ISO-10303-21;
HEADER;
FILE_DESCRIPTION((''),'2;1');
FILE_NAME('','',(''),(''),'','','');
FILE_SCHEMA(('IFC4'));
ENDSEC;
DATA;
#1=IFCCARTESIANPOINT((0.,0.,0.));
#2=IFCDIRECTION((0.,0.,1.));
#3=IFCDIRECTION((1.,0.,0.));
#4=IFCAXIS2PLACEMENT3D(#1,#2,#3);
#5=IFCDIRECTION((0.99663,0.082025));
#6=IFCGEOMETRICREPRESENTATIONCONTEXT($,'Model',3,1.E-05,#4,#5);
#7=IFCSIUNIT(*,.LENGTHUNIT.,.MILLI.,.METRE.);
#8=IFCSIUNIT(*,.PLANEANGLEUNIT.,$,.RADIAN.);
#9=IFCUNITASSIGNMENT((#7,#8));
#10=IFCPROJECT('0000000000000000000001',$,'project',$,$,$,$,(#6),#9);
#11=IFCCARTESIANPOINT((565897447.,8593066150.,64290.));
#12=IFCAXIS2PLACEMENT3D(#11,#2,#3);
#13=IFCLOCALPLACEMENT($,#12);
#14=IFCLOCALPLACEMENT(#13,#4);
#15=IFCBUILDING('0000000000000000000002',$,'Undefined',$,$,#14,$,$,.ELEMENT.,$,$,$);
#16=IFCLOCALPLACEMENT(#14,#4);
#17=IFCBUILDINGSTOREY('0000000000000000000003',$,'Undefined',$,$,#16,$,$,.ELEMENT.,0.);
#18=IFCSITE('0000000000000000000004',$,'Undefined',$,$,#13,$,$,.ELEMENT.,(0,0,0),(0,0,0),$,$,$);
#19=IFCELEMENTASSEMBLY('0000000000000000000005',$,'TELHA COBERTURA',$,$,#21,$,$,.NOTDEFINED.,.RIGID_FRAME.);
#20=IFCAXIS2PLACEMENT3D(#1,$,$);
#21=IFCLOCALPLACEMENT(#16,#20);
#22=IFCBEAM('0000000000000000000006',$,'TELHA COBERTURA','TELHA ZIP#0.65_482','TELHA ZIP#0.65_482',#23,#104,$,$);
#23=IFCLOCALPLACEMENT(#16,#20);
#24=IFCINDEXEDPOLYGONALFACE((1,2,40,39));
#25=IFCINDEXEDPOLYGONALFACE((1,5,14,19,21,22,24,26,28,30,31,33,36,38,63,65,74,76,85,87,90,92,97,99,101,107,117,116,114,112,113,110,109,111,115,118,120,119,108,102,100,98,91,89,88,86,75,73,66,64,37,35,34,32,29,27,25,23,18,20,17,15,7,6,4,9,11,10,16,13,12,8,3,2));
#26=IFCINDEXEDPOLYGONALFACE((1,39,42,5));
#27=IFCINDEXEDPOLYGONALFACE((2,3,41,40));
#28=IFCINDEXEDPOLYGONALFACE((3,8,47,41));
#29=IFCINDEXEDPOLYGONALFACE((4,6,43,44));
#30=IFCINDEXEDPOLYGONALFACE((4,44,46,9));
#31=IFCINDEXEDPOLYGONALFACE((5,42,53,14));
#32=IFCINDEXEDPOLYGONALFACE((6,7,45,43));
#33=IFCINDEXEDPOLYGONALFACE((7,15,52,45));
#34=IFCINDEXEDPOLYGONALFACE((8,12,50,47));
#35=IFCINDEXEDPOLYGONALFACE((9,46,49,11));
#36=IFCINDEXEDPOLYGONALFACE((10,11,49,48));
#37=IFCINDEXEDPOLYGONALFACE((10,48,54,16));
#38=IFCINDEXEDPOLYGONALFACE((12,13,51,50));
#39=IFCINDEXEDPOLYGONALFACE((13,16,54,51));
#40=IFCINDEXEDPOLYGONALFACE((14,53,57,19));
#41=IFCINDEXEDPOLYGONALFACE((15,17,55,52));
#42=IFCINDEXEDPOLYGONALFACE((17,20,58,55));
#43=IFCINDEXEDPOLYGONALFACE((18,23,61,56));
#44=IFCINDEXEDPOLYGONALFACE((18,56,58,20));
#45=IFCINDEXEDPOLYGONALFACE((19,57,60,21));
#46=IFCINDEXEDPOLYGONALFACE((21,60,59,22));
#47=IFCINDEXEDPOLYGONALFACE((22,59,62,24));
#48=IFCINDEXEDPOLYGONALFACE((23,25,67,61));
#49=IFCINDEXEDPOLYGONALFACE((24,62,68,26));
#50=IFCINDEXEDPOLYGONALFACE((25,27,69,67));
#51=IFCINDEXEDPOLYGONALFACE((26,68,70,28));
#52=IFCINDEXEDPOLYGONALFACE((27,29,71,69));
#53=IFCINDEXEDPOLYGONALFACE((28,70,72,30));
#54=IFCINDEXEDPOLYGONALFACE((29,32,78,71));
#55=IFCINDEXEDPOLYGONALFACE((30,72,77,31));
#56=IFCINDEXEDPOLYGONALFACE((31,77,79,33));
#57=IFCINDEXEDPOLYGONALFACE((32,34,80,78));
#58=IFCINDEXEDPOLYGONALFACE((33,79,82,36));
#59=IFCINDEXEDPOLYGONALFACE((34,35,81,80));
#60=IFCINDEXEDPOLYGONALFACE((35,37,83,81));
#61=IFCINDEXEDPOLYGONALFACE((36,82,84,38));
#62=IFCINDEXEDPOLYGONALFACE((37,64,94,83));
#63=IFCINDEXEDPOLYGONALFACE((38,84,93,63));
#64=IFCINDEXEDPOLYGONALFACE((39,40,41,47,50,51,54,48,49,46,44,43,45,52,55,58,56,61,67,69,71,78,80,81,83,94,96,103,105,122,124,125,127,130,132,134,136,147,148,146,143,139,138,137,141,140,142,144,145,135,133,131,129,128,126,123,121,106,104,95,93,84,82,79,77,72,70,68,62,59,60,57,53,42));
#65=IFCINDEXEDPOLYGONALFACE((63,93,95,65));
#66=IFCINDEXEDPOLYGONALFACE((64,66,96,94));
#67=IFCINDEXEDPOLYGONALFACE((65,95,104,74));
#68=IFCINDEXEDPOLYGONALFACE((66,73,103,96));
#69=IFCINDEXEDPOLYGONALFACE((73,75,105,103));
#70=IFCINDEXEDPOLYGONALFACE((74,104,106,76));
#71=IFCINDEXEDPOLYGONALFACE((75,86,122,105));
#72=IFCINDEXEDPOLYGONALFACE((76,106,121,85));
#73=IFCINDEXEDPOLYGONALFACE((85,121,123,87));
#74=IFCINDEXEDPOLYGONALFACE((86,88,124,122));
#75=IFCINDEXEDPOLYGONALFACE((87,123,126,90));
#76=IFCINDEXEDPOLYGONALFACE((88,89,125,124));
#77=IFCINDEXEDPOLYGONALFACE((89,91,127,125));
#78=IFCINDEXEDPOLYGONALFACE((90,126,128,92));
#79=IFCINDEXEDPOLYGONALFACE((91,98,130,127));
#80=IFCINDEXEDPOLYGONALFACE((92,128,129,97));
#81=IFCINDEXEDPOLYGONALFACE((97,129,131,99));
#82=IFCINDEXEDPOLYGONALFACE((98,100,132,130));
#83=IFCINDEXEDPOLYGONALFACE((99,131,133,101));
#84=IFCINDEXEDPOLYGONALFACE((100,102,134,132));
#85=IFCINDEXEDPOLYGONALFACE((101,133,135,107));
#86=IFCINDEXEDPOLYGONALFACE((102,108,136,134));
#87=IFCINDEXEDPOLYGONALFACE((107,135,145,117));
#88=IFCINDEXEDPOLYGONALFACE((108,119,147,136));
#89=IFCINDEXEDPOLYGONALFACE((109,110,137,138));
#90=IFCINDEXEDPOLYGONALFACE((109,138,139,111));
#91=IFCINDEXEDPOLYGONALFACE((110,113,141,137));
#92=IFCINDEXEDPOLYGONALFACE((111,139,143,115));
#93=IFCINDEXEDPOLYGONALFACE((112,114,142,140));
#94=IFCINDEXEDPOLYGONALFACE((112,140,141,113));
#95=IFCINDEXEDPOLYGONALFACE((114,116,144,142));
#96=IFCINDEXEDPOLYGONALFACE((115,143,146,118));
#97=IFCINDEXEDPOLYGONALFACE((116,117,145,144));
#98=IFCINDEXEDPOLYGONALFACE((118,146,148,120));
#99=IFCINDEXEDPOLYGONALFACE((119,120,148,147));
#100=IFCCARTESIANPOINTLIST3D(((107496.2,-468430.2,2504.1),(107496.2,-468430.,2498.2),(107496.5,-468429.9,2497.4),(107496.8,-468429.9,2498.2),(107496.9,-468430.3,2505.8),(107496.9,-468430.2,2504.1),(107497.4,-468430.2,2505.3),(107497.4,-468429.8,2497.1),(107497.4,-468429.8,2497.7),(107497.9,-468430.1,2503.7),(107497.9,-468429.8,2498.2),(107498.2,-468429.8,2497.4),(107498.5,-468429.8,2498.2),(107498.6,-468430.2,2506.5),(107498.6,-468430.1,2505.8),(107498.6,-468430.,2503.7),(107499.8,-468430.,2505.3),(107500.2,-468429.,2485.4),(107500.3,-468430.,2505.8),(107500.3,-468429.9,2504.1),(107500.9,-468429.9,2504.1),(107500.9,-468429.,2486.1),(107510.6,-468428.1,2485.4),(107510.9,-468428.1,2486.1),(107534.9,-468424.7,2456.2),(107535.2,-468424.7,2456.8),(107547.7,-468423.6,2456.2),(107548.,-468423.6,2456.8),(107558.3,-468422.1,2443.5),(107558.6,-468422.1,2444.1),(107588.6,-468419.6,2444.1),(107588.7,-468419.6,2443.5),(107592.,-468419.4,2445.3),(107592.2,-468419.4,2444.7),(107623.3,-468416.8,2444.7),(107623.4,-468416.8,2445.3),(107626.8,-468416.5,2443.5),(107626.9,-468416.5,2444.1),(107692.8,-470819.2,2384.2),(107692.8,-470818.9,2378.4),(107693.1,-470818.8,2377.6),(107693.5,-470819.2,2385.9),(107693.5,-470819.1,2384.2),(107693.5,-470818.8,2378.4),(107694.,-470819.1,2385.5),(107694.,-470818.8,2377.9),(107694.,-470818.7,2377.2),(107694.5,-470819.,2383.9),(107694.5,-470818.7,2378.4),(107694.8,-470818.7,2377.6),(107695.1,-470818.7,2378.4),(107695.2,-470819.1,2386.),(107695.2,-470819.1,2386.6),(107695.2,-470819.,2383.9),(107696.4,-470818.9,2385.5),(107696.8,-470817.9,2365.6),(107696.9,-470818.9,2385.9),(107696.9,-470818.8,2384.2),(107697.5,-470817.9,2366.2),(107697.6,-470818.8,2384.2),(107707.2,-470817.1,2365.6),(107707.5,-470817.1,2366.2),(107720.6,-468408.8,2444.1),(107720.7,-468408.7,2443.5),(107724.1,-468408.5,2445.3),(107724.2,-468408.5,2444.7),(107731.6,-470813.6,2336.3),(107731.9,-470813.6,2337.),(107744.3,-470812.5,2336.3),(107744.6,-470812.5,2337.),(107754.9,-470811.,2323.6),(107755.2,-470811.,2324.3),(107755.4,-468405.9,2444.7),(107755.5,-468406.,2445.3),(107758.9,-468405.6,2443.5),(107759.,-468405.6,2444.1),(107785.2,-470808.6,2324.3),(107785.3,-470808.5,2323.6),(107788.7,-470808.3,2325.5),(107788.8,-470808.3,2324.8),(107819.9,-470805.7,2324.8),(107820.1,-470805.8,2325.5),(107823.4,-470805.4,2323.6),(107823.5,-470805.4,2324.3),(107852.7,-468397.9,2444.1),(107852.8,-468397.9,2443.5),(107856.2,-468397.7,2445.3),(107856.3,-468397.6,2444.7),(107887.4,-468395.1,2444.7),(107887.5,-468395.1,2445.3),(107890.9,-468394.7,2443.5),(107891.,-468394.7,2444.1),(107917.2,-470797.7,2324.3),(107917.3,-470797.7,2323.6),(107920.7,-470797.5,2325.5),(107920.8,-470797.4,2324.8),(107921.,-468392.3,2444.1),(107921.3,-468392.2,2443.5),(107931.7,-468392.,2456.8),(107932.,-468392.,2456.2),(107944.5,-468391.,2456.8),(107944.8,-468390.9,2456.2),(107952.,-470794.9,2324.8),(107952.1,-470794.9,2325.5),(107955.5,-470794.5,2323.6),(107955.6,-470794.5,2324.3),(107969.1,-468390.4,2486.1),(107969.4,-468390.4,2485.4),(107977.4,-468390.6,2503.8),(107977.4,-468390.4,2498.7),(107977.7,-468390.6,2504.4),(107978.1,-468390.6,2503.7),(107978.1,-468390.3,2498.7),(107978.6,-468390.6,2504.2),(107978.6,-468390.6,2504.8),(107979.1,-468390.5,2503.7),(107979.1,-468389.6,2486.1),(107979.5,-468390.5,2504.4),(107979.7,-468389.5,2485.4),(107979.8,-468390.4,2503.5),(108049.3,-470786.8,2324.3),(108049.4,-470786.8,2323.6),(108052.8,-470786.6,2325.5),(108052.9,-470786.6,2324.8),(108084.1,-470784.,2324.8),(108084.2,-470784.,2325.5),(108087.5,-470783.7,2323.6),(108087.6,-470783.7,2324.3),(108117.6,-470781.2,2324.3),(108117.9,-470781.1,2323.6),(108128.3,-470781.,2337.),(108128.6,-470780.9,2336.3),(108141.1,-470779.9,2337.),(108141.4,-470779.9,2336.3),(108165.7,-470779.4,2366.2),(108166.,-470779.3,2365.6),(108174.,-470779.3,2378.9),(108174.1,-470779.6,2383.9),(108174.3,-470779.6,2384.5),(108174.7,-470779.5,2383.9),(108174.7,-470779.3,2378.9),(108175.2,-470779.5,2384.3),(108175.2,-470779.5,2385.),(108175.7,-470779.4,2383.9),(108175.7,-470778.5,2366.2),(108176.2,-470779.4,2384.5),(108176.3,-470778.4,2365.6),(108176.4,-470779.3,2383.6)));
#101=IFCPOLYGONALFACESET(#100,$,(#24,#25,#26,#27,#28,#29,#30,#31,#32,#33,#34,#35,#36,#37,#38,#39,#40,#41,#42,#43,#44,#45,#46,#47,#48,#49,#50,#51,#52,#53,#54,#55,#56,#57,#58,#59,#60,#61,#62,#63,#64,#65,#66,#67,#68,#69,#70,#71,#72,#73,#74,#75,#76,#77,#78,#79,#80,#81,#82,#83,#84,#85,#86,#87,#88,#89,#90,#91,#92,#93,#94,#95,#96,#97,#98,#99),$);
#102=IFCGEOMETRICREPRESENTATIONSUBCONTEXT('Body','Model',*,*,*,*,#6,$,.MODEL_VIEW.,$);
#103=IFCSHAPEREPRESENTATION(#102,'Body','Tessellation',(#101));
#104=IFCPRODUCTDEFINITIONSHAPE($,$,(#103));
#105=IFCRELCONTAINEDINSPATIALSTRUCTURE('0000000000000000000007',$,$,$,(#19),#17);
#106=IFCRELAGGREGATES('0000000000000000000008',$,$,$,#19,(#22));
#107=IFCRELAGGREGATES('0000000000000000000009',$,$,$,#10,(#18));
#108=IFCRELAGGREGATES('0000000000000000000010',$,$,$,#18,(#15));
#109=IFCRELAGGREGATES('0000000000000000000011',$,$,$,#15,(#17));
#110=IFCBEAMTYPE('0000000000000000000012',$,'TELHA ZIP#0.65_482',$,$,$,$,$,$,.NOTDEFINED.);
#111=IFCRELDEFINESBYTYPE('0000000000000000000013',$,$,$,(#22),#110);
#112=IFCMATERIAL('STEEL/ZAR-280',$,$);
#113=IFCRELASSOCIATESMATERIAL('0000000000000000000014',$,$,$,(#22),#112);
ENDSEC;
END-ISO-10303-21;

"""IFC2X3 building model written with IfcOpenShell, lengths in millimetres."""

from ifc_helpers import new_model, si_unit, direction, frame, origin_with_axes, place, context, subcontext, project, spatial, polyline, outline, extrude, material, type_object, element, aggregate, save


model = new_model("IFC2X3")

# Units and contexts
model_context = context("Model", 3, precision=1e-05, world=origin_with_axes(), true_north=direction((0.99663, 0.082025)))
body_context = subcontext(model_context, "Body", "Model", "MODEL_VIEW")
ifc_project = project(units=[si_unit("LENGTHUNIT", "METRE", prefix="MILLI"), si_unit("PLANEANGLEUNIT", "RADIAN")], contexts=[model_context])

# Site, building, storey
site_placement = place(None, frame((565897447.0, 8593066150.0, 64290.0), z_axis=(0.0, 0.0, 1.0), x_axis=(1.0, 0.0, 0.0)))
site = spatial("IfcSite", under=ifc_project, at=site_placement, Name="Undefined", CompositionType="ELEMENT", RefLatitude=(0, 0, 0), RefLongitude=(0, 0, 0))
building_placement = place(site_placement, origin_with_axes())
building = spatial("IfcBuilding", under=site, at=building_placement, Name="Undefined", CompositionType="ELEMENT")
storey_placement = place(building_placement, origin_with_axes())
storey = spatial("IfcBuildingStorey", under=building, at=storey_placement, Name="Undefined", CompositionType="ELEMENT", Elevation=0.0)

# Element assembly, beam
ifc_material_1 = material(Name="STEEL/ZAR-280")
beam_type_1 = type_object("IfcBeamType", Name="TELHA ZIP#0.65_482", PredefinedType="NOTDEFINED")
assembly_1_placement = place(storey_placement, origin_with_axes())
assembly_1 = element("IfcElementAssembly", 1, at=assembly_1_placement, inside=storey, Name="TELHA COBERTURA", AssemblyPlace="NOTDEFINED", PredefinedType="RIGID_FRAME")
beam_1_placement = place(assembly_1_placement, frame((107934.5, -470797.8, 2354.8), z_axis=(0.004096, -0.049769, 0.998752), x_axis=(-0.081923, 0.995387, 0.049938)))
beam_1 = element("IfcBeam", 2, at=beam_1_placement, type_object=beam_type_1, material=ifc_material_1, Name="TELHA COBERTURA", Description="TELHA ZIP#0.65_482", ObjectType="TELHA ZIP#0.65_482", context=body_context, shape_type="SweptSolid", body=[
    extrude(outline(polyline([(240.5, 29.7), (241.4, 30.2), (242.4, 29.7), (242.6, 28.9), (242.6, 10.8), (232.2, 10.8), (207.6, -18.5), (194.9, -18.5), (184.2, -31.2), (153.7, -31.2), (150.2, -30.0), (118.9, -30.0), (115.4, -31.2), (21.2, -31.2), (17.7, -30.0), (-13.6, -30.0), (-17.1, -31.2), (-111.3, -31.2), (-114.8, -30.0), (-146.1, -30.0), (-149.6, -31.2), (-180.1, -31.2), (-190.8, -18.5), (-203.6, -18.5), (-228.1, 10.8), (-238.5, 10.8), (-238.5, 29.5), (-239.0, 30.7), (-240.2, 31.2), (-241.4, 30.7), (-241.9, 29.5), (-241.9, 23.6), (-241.4, 23.1), (-240.9, 23.6), (-240.9, 29.1), (-240.2, 29.1), (-240.2, 23.6), (-240.6, 22.8), (-241.4, 22.4), (-242.3, 22.8), (-242.6, 23.6), (-242.6, 29.5), (-241.9, 31.2), (-240.2, 31.9), (-238.5, 31.2), (-237.9, 29.5), (-237.9, 11.4), (-227.8, 11.4), (-203.2, -17.9), (-190.4, -17.9), (-179.8, -30.5), (-149.7, -30.5), (-146.2, -29.4), (-114.7, -29.4), (-111.2, -30.5), (-17.2, -30.5), (-13.7, -29.4), (17.8, -29.4), (21.3, -30.5), (115.3, -30.5), (118.8, -29.4), (150.3, -29.4), (153.8, -30.5), (183.9, -30.5), (194.6, -17.9), (207.4, -17.9), (231.9, 11.4), (241.9, 11.4), (241.9, 29.1), (241.4, 29.5), (240.9, 29.1), (240.9, 24.1), (240.2, 24.1), (240.2, 29.2), (240.5, 29.7)])), frame((2400.0, 0.0, 0.0), z_axis=(-1.0, 0.0, 0.0), x_axis=(0.0, -1.0, 0.0)), (0.0, 0.0, 1.0), 2400.0),
])
aggregate(assembly_1, [beam_1])

save(model, "model.ifc")
